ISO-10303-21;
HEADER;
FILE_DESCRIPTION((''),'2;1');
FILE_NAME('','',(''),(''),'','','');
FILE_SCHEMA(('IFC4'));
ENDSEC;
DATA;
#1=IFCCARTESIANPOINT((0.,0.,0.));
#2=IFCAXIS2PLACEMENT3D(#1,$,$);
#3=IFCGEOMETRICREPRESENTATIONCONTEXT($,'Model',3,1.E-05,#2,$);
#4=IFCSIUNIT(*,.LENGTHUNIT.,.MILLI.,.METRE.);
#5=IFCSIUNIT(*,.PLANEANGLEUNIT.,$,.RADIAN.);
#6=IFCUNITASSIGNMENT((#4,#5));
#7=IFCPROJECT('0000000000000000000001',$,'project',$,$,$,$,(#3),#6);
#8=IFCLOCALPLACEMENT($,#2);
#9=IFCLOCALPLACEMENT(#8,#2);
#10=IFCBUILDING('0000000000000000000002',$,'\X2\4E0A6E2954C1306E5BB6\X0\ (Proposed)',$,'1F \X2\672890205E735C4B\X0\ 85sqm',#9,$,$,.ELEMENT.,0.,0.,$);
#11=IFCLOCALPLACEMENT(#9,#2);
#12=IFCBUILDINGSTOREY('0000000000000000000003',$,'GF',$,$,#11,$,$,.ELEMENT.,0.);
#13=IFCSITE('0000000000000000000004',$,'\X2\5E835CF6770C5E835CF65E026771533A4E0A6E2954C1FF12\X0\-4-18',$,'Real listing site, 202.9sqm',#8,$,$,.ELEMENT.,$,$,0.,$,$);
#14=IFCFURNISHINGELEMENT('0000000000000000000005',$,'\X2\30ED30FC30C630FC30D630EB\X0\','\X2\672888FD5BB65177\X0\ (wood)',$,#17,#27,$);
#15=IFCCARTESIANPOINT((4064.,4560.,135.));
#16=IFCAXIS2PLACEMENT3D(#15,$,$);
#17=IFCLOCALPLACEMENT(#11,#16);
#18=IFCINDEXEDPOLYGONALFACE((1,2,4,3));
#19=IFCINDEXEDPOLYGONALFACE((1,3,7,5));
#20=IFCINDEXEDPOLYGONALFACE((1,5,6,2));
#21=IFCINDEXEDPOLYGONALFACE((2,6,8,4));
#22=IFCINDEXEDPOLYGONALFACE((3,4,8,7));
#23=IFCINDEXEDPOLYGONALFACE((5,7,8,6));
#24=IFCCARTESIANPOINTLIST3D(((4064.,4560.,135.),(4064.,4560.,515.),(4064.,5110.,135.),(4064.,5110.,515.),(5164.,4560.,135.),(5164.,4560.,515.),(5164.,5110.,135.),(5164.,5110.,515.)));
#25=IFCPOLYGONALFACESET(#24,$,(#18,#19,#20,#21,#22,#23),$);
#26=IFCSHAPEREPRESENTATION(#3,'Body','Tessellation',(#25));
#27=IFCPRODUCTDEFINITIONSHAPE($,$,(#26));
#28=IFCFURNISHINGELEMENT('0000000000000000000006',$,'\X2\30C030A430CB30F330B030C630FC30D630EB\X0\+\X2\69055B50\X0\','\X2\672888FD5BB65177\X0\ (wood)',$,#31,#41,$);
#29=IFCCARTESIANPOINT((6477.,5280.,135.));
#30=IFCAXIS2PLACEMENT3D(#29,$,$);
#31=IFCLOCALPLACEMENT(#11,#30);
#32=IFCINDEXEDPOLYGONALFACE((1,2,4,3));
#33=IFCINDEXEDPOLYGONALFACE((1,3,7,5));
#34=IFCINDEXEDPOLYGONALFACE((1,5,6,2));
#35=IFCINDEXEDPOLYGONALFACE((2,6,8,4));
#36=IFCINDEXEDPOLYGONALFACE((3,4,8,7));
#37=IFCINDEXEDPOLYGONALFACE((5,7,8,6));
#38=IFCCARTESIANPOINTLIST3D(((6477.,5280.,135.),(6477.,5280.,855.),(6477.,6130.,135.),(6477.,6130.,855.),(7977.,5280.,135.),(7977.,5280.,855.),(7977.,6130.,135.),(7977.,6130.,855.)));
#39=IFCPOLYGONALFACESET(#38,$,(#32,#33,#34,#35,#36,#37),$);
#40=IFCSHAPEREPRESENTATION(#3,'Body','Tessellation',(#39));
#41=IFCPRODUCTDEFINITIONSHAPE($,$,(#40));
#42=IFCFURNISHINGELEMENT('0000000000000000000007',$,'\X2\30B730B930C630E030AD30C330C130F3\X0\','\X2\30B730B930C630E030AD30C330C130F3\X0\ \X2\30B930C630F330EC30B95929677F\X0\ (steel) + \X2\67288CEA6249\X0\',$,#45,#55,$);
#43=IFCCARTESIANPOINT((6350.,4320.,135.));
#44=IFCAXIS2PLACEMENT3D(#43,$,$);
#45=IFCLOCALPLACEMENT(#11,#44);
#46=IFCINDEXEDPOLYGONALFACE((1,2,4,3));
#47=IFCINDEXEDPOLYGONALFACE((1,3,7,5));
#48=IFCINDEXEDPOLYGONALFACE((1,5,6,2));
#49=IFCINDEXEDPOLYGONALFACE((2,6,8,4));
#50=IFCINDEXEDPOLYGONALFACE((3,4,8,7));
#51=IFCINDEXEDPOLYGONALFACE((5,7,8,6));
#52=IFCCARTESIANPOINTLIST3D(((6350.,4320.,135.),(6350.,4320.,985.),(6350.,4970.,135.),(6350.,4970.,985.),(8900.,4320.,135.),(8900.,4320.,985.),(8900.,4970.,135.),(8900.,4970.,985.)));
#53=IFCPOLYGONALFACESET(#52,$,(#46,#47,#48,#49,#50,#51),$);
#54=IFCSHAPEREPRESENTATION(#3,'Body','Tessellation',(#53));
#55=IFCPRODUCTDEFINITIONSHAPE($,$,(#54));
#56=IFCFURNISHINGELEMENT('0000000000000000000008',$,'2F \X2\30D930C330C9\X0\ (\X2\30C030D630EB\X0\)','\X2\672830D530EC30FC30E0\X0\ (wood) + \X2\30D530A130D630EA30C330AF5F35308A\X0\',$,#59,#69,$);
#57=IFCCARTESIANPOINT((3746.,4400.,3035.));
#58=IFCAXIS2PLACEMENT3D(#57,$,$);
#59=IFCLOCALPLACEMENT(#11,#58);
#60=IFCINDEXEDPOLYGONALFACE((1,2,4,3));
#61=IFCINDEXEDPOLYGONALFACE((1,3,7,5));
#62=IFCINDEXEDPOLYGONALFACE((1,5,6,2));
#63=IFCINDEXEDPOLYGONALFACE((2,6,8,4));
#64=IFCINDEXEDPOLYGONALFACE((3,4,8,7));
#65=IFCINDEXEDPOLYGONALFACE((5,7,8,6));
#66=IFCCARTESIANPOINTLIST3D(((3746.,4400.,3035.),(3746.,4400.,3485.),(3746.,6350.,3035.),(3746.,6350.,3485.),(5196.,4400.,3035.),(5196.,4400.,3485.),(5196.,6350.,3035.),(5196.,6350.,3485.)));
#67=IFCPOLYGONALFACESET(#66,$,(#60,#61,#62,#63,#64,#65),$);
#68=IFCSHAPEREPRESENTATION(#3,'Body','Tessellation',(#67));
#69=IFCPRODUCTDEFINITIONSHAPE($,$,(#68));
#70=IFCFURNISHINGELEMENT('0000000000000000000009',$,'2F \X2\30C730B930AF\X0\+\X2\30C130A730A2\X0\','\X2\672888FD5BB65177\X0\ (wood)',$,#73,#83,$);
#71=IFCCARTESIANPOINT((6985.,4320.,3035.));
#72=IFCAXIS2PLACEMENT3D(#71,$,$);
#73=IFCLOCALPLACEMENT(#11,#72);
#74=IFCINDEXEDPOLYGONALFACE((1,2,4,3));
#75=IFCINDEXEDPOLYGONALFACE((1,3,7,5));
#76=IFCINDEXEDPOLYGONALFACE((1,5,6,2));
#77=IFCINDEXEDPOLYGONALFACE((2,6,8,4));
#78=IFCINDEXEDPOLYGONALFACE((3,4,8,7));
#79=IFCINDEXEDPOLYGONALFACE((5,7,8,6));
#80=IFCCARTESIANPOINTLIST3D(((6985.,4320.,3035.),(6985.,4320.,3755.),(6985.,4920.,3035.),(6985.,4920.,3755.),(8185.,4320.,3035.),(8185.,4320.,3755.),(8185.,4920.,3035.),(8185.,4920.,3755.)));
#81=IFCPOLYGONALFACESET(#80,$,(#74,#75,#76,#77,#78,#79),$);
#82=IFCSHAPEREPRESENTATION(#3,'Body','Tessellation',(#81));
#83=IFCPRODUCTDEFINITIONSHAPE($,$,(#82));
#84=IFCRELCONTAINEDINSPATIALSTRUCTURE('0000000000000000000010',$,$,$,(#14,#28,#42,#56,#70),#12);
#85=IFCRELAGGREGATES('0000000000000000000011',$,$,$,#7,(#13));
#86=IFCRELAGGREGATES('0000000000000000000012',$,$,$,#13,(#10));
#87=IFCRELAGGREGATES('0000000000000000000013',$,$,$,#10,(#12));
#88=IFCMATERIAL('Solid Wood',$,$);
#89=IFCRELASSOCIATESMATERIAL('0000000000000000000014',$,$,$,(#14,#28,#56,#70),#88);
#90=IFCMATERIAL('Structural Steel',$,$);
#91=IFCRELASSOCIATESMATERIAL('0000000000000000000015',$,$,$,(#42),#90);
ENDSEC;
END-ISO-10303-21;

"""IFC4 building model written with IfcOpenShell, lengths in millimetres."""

from ifc_helpers import new_model, si_unit, frame, frame_2d, origin, place, context, project, spatial, rectangle, extrude, material, element, save


model = new_model("IFC4")

# Units and contexts
model_context = context("Model", 3, precision=1e-05, world=origin())
ifc_project = project(units=[si_unit("LENGTHUNIT", "METRE", prefix="MILLI"), si_unit("PLANEANGLEUNIT", "RADIAN")], contexts=[model_context])

# Site, building, storey
site_placement = place(None, origin())
site = spatial("IfcSite", under=ifc_project, at=site_placement, Name="広島県広島市東区上温品２-4-18", ObjectType="Real listing site, 202.9sqm", CompositionType="ELEMENT", RefElevation=0.0)
building_placement = place(site_placement, origin())
building = spatial("IfcBuilding", under=site, at=building_placement, Name="上温品の家 (Proposed)", ObjectType="1F 木造平屋 85sqm", CompositionType="ELEMENT", ElevationOfRefHeight=0.0, ElevationOfTerrain=0.0)
storey_placement = place(building_placement, origin())
storey = spatial("IfcBuildingStorey", under=building, at=storey_placement, Name="GF", CompositionType="ELEMENT", Elevation=0.0)

# Shared definitions
ifc_material_1 = material(Name="Solid Wood")

# Shared definitions
ifc_material_2 = material(Name="Structural Steel")

# Furnishing elements
furnishing_1_placement = place(storey_placement, frame((4064.0, 4560.0, 135.0)))
element("IfcFurnishingElement", 1, at=furnishing_1_placement, inside=storey, material=ifc_material_1, Name="ローテーブル", Description="木製家具 (wood)", context=model_context, shape_type="SweptSolid", body=[
    extrude(rectangle(XDim=1100.0, YDim=550.0, at=frame_2d((550.0, 275.0))), frame((4064.0, 4560.0, 135.0)), (0.0, 0.0, 1.0), 380.0),
])
furnishing_2_placement = place(storey_placement, frame((6477.0, 5280.0, 135.0)))
element("IfcFurnishingElement", 2, at=furnishing_2_placement, inside=storey, material=ifc_material_1, Name="ダイニングテーブル+椅子", Description="木製家具 (wood)", context=model_context, shape_type="SweptSolid", body=[
    extrude(rectangle(XDim=1500.0, YDim=850.0, at=frame_2d((750.0, 425.0))), frame((6477.0, 5280.0, 135.0)), (0.0, 0.0, 1.0), 720.0),
])
furnishing_3_placement = place(storey_placement, frame((6350.0, 4320.0, 135.0)))
element("IfcFurnishingElement", 3, at=furnishing_3_placement, inside=storey, material=ifc_material_2, Name="システムキッチン", Description="システムキッチン ステンレス天板 (steel) + 木質扉", context=model_context, shape_type="SweptSolid", body=[
    extrude(rectangle(XDim=2550.0, YDim=650.0, at=frame_2d((1275.0, 325.0))), frame((6350.0, 4320.0, 135.0)), (0.0, 0.0, 1.0), 850.0),
])
furnishing_4_placement = place(storey_placement, frame((3746.0, 4400.0, 3035.0)))
element("IfcFurnishingElement", 4, at=furnishing_4_placement, inside=storey, material=ifc_material_1, Name="2F ベッド (ダブル)", Description="木フレーム (wood) + ファブリック張り", context=model_context, shape_type="SweptSolid", body=[
    extrude(rectangle(XDim=1450.0, YDim=1950.0, at=frame_2d((725.0, 975.0))), frame((3746.0, 4400.0, 3035.0)), (0.0, 0.0, 1.0), 450.0),
])
furnishing_5_placement = place(storey_placement, frame((6985.0, 4320.0, 3035.0)))
element("IfcFurnishingElement", 5, at=furnishing_5_placement, inside=storey, material=ifc_material_1, Name="2F デスク+チェア", Description="木製家具 (wood)", context=model_context, shape_type="SweptSolid", body=[
    extrude(rectangle(XDim=1200.0, YDim=600.0, at=frame_2d((600.0, 300.0))), frame((6985.0, 4320.0, 3035.0)), (0.0, 0.0, 1.0), 720.0),
])

save(model, "model.ifc")
